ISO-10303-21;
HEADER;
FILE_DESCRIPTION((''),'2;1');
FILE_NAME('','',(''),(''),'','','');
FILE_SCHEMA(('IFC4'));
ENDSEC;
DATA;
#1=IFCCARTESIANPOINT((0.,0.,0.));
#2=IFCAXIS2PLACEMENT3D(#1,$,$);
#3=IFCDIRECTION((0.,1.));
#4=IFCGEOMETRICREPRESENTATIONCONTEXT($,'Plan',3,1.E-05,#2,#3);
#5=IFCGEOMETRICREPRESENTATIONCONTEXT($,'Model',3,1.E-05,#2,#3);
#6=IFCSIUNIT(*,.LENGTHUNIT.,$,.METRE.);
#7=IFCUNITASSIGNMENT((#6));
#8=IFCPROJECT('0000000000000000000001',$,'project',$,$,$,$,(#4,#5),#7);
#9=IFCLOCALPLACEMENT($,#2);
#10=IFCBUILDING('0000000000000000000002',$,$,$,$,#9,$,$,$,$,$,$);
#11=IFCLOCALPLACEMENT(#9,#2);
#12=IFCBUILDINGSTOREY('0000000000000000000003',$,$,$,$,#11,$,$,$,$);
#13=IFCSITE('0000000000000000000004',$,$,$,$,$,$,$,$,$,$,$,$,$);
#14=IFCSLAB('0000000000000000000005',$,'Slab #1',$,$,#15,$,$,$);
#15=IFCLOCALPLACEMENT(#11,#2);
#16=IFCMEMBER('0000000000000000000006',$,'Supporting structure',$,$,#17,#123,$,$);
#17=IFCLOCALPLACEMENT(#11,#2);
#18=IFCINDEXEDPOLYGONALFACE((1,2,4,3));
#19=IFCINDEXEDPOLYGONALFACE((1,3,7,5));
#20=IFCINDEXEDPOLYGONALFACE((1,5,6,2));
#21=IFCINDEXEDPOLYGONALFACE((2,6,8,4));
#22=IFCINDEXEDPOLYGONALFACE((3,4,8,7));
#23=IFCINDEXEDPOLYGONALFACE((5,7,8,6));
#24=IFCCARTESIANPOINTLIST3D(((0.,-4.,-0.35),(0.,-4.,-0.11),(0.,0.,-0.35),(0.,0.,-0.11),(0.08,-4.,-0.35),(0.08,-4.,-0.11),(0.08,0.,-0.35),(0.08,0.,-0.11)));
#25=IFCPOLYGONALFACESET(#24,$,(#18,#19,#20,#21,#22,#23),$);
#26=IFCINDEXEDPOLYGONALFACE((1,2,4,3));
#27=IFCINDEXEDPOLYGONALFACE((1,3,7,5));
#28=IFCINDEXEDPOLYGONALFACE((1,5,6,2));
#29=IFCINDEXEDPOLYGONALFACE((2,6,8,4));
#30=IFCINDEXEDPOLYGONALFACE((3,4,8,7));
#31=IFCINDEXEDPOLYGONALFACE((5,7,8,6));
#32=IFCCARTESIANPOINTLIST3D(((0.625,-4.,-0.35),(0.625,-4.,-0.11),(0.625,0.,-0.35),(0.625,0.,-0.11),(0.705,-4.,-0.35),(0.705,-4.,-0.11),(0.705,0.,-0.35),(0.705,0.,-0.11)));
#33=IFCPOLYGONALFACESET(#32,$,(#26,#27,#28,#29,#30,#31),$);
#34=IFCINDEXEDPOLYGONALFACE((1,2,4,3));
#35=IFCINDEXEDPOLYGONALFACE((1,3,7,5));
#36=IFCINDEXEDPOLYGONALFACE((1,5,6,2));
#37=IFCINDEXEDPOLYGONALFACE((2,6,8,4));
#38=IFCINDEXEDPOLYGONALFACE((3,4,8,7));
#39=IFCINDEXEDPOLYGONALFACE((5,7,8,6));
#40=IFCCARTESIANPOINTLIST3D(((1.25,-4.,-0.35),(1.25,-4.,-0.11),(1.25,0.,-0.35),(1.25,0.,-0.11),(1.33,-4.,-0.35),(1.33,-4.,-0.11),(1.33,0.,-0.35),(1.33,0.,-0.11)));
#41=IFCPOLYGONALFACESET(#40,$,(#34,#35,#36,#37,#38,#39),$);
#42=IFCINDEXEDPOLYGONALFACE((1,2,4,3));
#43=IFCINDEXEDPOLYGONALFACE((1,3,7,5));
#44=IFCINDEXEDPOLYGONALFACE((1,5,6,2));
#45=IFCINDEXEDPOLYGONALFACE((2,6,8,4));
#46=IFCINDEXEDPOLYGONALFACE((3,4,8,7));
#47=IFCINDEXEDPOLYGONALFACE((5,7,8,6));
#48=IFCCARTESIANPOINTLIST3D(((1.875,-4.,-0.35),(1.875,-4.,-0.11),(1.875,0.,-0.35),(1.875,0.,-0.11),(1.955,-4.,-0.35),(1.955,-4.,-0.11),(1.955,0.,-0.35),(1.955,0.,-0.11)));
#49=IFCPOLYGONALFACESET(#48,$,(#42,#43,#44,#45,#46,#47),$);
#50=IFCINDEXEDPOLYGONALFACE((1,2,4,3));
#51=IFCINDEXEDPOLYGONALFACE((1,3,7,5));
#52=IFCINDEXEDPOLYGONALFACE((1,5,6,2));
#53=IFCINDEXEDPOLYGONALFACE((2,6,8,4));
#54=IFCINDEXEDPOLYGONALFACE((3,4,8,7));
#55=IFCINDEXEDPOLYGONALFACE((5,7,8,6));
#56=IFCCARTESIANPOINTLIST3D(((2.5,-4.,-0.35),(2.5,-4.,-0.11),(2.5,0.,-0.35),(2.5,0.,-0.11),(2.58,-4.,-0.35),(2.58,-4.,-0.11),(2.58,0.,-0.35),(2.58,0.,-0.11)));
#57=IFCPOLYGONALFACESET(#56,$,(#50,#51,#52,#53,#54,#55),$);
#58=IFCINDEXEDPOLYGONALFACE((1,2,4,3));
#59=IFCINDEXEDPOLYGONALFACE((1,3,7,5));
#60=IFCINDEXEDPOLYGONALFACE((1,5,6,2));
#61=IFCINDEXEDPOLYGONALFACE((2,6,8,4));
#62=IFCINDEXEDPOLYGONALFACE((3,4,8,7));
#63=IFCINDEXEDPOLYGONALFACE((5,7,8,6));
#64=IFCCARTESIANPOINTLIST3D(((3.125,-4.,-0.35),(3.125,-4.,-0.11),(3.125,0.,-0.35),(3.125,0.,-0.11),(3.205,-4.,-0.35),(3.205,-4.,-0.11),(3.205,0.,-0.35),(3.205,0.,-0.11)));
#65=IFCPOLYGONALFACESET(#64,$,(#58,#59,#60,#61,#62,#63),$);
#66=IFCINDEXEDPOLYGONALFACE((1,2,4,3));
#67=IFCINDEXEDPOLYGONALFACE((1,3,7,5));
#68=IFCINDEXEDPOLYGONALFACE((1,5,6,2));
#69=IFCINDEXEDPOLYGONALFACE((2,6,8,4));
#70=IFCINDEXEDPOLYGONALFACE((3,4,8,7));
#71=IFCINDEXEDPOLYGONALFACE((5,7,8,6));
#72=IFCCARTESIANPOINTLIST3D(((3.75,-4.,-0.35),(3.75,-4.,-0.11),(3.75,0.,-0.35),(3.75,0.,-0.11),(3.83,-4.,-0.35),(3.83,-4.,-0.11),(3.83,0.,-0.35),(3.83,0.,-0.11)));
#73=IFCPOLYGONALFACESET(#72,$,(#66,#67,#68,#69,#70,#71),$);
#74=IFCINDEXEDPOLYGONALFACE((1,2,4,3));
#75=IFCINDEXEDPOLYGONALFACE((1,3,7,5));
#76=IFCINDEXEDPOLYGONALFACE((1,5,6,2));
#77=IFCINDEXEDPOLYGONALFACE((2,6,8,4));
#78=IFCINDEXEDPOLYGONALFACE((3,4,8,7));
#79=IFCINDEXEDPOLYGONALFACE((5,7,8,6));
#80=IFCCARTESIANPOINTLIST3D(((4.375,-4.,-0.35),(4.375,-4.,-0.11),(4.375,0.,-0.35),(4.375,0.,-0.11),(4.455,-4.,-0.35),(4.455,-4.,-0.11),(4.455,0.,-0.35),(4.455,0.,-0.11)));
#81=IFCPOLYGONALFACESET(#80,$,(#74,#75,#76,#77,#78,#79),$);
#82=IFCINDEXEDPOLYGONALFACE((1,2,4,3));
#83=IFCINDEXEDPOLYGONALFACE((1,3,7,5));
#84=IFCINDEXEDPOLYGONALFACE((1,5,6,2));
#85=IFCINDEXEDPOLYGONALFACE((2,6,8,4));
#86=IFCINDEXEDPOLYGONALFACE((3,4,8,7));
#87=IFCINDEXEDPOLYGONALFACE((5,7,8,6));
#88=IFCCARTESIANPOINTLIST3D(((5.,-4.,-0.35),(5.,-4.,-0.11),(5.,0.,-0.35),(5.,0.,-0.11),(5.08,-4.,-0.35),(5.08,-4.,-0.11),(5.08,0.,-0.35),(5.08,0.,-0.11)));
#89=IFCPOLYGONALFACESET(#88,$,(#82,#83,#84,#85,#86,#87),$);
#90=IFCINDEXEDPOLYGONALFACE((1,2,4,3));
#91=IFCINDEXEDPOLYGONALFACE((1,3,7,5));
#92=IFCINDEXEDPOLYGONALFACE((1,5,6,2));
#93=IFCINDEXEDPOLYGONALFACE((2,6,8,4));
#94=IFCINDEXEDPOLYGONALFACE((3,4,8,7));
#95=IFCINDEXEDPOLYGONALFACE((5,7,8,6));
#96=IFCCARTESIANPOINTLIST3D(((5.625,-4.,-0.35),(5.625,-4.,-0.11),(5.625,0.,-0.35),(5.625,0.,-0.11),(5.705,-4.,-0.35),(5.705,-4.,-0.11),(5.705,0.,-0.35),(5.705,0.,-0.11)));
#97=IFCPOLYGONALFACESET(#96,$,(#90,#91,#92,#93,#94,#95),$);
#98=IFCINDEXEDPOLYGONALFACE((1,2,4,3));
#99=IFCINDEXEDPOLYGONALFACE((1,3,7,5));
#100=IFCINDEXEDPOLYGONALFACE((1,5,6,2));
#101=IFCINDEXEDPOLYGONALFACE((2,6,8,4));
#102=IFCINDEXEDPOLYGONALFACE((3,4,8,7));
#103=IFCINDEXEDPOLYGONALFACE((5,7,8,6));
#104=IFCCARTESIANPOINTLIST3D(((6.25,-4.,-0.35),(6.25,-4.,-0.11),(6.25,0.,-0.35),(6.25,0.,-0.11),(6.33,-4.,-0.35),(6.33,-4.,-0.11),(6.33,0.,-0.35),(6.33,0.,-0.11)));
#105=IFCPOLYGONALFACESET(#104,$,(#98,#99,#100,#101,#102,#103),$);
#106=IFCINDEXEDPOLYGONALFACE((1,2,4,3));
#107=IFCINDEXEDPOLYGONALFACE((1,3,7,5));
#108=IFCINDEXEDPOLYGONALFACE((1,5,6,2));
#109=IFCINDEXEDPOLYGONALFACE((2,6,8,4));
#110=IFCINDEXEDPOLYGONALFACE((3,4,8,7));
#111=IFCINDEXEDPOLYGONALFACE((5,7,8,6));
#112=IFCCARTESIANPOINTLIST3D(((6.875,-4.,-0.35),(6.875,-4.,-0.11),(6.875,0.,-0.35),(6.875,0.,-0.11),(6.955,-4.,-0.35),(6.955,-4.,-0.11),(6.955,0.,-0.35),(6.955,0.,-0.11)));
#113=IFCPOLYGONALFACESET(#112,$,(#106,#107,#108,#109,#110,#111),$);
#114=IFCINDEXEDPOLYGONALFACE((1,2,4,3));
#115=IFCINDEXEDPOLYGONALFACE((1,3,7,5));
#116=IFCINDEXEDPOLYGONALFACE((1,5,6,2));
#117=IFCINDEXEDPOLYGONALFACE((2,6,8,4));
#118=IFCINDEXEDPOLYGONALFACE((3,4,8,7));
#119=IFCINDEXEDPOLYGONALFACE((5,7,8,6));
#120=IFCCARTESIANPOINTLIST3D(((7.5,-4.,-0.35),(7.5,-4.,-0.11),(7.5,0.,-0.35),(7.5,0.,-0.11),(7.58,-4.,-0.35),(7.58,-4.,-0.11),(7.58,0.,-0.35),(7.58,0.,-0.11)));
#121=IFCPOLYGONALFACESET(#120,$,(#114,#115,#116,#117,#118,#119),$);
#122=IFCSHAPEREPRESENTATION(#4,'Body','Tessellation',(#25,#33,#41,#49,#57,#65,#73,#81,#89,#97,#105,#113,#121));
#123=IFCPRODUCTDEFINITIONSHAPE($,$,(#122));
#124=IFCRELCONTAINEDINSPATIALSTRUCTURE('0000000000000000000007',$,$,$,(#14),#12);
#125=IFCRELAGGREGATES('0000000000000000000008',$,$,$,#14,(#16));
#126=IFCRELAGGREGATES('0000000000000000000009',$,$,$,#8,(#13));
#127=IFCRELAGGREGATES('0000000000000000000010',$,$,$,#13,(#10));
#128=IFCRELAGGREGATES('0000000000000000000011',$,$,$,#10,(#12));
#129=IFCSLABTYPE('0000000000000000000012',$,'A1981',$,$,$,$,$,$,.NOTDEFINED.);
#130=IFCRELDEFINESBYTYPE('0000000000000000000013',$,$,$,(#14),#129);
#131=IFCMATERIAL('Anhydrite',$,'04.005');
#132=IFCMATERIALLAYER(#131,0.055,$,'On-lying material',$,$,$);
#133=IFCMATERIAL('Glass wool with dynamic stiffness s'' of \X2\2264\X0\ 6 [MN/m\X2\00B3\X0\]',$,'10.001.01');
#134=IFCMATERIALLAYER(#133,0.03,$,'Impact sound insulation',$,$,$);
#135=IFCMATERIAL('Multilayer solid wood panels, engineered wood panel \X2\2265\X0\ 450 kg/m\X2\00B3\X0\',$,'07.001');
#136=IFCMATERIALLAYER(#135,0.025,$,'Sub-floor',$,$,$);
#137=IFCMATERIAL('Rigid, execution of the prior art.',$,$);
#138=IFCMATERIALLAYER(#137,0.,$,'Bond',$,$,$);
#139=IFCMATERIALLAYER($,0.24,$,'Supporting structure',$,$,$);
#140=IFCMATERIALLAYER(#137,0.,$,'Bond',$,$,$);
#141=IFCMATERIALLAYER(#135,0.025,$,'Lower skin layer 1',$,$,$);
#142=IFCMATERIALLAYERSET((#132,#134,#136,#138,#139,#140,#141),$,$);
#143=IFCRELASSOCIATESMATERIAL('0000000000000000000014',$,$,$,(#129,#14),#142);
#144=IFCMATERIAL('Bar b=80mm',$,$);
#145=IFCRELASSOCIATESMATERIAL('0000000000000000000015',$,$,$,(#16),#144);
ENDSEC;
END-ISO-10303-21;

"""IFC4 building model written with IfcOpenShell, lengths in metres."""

from ifc_helpers import new_model, si_unit, direction, frame, frame_2d, origin, place, context, project, spatial, rectangle, extrude, material, layer, layer_set, type_object, element, aggregate, save


model = new_model("IFC4")

# Units and contexts
plan_context = context("Plan", 3, precision=1e-05, world=origin(), true_north=direction((0.0, 1.0)))
model_context = context("Model", 3, precision=1e-05, world=origin(), true_north=direction((0.0, 1.0)))
ifc_project = project(units=[si_unit("LENGTHUNIT", "METRE")], contexts=[plan_context, model_context])

# Site, building, storey
site = spatial("IfcSite", under=ifc_project)
building_placement = place(None, origin())
building = spatial("IfcBuilding", under=site, at=building_placement)
storey_placement = place(building_placement, origin())
storey = spatial("IfcBuildingStorey", under=building, at=storey_placement)

# Slab, member
ifc_material_1 = material(Name="Anhydrite", Category="04.005")
ifc_layer_1 = layer(ifc_material_1, 0.055, Name="On-lying material")
ifc_material_2 = material(Name="Glass wool with dynamic stiffness s' of ≤ 6 [MN/m³]", Category="10.001.01")
ifc_layer_2 = layer(ifc_material_2, 0.03, Name="Impact sound insulation")
ifc_material_3 = material(Name="Multilayer solid wood panels, engineered wood panel ≥ 450 kg/m³", Category="07.001")
ifc_layer_3 = layer(ifc_material_3, 0.025, Name="Sub-floor")
ifc_material_4 = material(Name="Rigid, execution of the prior art.")
ifc_layer_4 = layer(ifc_material_4, 0.0, Name="Bond")
ifc_layer_5 = layer(None, 0.24, Name="Supporting structure")
ifc_layer_6 = layer(ifc_material_4, 0.0, Name="Bond")
ifc_layer_7 = layer(ifc_material_3, 0.025, Name="Lower skin layer 1")
ifc_layer_set = layer_set([ifc_layer_1, ifc_layer_2, ifc_layer_3, ifc_layer_4, ifc_layer_5, ifc_layer_6, ifc_layer_7])
slab_type = type_object("IfcSlabType", Name="A1981", PredefinedType="NOTDEFINED", material=ifc_layer_set)
slab_placement = place(None, frame((0.0, 0.0, 0.0), z_axis=(0.0, 0.0, -1.0), x_axis=(1.0, 0.0, 0.0)))
slab = element("IfcSlab", 1, at=slab_placement, inside=storey, type_object=slab_type, material=ifc_layer_set, Name="Slab #1")
ifc_material_5 = material(Name="Bar b=80mm")
member_1_placement = place(slab_placement, origin())
member_1 = element("IfcMember", 2, at=member_1_placement, material=ifc_material_5, Name="Supporting structure", context=plan_context, shape_type="SweptSolid", body=[
    extrude(rectangle(XDim=0.08, YDim=0.24, at=frame_2d((0.04, 0.12), x_axis=(1.0, 0.0))), frame((0.0, 4.0, 0.11), z_axis=(0.0, -1.0, 0.0), x_axis=(1.0, 0.0, 0.0)), (0.0, 0.0, 1.0), 4.0),
    extrude(rectangle(XDim=0.08, YDim=0.24, at=frame_2d((0.04, 0.12), x_axis=(1.0, 0.0))), frame((0.625, 4.0, 0.11), z_axis=(0.0, -1.0, 0.0), x_axis=(1.0, 0.0, 0.0)), (0.0, 0.0, 1.0), 4.0),
    extrude(rectangle(XDim=0.08, YDim=0.24, at=frame_2d((0.04, 0.12), x_axis=(1.0, 0.0))), frame((1.25, 4.0, 0.11), z_axis=(0.0, -1.0, 0.0), x_axis=(1.0, 0.0, 0.0)), (0.0, 0.0, 1.0), 4.0),
    extrude(rectangle(XDim=0.08, YDim=0.24, at=frame_2d((0.04, 0.12), x_axis=(1.0, 0.0))), frame((1.875, 4.0, 0.11), z_axis=(0.0, -1.0, 0.0), x_axis=(1.0, 0.0, 0.0)), (0.0, 0.0, 1.0), 4.0),
    extrude(rectangle(XDim=0.08, YDim=0.24, at=frame_2d((0.04, 0.12), x_axis=(1.0, 0.0))), frame((2.5, 4.0, 0.11), z_axis=(0.0, -1.0, 0.0), x_axis=(1.0, 0.0, 0.0)), (0.0, 0.0, 1.0), 4.0),
    extrude(rectangle(XDim=0.08, YDim=0.24, at=frame_2d((0.04, 0.12), x_axis=(1.0, 0.0))), frame((3.125, 4.0, 0.11), z_axis=(0.0, -1.0, 0.0), x_axis=(1.0, 0.0, 0.0)), (0.0, 0.0, 1.0), 4.0),
    extrude(rectangle(XDim=0.08, YDim=0.24, at=frame_2d((0.04, 0.12), x_axis=(1.0, 0.0))), frame((3.75, 4.0, 0.11), z_axis=(0.0, -1.0, 0.0), x_axis=(1.0, 0.0, 0.0)), (0.0, 0.0, 1.0), 4.0),
    extrude(rectangle(XDim=0.08, YDim=0.24, at=frame_2d((0.04, 0.12), x_axis=(1.0, 0.0))), frame((4.375, 4.0, 0.11), z_axis=(0.0, -1.0, 0.0), x_axis=(1.0, 0.0, 0.0)), (0.0, 0.0, 1.0), 4.0),
    extrude(rectangle(XDim=0.08, YDim=0.24, at=frame_2d((0.04, 0.12), x_axis=(1.0, 0.0))), frame((5.0, 4.0, 0.11), z_axis=(0.0, -1.0, 0.0), x_axis=(1.0, 0.0, 0.0)), (0.0, 0.0, 1.0), 4.0),
    extrude(rectangle(XDim=0.08, YDim=0.24, at=frame_2d((0.04, 0.12), x_axis=(1.0, 0.0))), frame((5.625, 4.0, 0.11), z_axis=(0.0, -1.0, 0.0), x_axis=(1.0, 0.0, 0.0)), (0.0, 0.0, 1.0), 4.0),
    extrude(rectangle(XDim=0.08, YDim=0.24, at=frame_2d((0.04, 0.12), x_axis=(1.0, 0.0))), frame((6.25, 4.0, 0.11), z_axis=(0.0, -1.0, 0.0), x_axis=(1.0, 0.0, 0.0)), (0.0, 0.0, 1.0), 4.0),
    extrude(rectangle(XDim=0.08, YDim=0.24, at=frame_2d((0.04, 0.12), x_axis=(1.0, 0.0))), frame((6.875, 4.0, 0.11), z_axis=(0.0, -1.0, 0.0), x_axis=(1.0, 0.0, 0.0)), (0.0, 0.0, 1.0), 4.0),
    extrude(rectangle(XDim=0.08, YDim=0.24, at=frame_2d((0.04, 0.12), x_axis=(1.0, 0.0))), frame((7.5, 4.0, 0.11), z_axis=(0.0, -1.0, 0.0), x_axis=(1.0, 0.0, 0.0)), (0.0, 0.0, 1.0), 4.0),
])
aggregate(slab, [member_1])

save(model, "model.ifc")
